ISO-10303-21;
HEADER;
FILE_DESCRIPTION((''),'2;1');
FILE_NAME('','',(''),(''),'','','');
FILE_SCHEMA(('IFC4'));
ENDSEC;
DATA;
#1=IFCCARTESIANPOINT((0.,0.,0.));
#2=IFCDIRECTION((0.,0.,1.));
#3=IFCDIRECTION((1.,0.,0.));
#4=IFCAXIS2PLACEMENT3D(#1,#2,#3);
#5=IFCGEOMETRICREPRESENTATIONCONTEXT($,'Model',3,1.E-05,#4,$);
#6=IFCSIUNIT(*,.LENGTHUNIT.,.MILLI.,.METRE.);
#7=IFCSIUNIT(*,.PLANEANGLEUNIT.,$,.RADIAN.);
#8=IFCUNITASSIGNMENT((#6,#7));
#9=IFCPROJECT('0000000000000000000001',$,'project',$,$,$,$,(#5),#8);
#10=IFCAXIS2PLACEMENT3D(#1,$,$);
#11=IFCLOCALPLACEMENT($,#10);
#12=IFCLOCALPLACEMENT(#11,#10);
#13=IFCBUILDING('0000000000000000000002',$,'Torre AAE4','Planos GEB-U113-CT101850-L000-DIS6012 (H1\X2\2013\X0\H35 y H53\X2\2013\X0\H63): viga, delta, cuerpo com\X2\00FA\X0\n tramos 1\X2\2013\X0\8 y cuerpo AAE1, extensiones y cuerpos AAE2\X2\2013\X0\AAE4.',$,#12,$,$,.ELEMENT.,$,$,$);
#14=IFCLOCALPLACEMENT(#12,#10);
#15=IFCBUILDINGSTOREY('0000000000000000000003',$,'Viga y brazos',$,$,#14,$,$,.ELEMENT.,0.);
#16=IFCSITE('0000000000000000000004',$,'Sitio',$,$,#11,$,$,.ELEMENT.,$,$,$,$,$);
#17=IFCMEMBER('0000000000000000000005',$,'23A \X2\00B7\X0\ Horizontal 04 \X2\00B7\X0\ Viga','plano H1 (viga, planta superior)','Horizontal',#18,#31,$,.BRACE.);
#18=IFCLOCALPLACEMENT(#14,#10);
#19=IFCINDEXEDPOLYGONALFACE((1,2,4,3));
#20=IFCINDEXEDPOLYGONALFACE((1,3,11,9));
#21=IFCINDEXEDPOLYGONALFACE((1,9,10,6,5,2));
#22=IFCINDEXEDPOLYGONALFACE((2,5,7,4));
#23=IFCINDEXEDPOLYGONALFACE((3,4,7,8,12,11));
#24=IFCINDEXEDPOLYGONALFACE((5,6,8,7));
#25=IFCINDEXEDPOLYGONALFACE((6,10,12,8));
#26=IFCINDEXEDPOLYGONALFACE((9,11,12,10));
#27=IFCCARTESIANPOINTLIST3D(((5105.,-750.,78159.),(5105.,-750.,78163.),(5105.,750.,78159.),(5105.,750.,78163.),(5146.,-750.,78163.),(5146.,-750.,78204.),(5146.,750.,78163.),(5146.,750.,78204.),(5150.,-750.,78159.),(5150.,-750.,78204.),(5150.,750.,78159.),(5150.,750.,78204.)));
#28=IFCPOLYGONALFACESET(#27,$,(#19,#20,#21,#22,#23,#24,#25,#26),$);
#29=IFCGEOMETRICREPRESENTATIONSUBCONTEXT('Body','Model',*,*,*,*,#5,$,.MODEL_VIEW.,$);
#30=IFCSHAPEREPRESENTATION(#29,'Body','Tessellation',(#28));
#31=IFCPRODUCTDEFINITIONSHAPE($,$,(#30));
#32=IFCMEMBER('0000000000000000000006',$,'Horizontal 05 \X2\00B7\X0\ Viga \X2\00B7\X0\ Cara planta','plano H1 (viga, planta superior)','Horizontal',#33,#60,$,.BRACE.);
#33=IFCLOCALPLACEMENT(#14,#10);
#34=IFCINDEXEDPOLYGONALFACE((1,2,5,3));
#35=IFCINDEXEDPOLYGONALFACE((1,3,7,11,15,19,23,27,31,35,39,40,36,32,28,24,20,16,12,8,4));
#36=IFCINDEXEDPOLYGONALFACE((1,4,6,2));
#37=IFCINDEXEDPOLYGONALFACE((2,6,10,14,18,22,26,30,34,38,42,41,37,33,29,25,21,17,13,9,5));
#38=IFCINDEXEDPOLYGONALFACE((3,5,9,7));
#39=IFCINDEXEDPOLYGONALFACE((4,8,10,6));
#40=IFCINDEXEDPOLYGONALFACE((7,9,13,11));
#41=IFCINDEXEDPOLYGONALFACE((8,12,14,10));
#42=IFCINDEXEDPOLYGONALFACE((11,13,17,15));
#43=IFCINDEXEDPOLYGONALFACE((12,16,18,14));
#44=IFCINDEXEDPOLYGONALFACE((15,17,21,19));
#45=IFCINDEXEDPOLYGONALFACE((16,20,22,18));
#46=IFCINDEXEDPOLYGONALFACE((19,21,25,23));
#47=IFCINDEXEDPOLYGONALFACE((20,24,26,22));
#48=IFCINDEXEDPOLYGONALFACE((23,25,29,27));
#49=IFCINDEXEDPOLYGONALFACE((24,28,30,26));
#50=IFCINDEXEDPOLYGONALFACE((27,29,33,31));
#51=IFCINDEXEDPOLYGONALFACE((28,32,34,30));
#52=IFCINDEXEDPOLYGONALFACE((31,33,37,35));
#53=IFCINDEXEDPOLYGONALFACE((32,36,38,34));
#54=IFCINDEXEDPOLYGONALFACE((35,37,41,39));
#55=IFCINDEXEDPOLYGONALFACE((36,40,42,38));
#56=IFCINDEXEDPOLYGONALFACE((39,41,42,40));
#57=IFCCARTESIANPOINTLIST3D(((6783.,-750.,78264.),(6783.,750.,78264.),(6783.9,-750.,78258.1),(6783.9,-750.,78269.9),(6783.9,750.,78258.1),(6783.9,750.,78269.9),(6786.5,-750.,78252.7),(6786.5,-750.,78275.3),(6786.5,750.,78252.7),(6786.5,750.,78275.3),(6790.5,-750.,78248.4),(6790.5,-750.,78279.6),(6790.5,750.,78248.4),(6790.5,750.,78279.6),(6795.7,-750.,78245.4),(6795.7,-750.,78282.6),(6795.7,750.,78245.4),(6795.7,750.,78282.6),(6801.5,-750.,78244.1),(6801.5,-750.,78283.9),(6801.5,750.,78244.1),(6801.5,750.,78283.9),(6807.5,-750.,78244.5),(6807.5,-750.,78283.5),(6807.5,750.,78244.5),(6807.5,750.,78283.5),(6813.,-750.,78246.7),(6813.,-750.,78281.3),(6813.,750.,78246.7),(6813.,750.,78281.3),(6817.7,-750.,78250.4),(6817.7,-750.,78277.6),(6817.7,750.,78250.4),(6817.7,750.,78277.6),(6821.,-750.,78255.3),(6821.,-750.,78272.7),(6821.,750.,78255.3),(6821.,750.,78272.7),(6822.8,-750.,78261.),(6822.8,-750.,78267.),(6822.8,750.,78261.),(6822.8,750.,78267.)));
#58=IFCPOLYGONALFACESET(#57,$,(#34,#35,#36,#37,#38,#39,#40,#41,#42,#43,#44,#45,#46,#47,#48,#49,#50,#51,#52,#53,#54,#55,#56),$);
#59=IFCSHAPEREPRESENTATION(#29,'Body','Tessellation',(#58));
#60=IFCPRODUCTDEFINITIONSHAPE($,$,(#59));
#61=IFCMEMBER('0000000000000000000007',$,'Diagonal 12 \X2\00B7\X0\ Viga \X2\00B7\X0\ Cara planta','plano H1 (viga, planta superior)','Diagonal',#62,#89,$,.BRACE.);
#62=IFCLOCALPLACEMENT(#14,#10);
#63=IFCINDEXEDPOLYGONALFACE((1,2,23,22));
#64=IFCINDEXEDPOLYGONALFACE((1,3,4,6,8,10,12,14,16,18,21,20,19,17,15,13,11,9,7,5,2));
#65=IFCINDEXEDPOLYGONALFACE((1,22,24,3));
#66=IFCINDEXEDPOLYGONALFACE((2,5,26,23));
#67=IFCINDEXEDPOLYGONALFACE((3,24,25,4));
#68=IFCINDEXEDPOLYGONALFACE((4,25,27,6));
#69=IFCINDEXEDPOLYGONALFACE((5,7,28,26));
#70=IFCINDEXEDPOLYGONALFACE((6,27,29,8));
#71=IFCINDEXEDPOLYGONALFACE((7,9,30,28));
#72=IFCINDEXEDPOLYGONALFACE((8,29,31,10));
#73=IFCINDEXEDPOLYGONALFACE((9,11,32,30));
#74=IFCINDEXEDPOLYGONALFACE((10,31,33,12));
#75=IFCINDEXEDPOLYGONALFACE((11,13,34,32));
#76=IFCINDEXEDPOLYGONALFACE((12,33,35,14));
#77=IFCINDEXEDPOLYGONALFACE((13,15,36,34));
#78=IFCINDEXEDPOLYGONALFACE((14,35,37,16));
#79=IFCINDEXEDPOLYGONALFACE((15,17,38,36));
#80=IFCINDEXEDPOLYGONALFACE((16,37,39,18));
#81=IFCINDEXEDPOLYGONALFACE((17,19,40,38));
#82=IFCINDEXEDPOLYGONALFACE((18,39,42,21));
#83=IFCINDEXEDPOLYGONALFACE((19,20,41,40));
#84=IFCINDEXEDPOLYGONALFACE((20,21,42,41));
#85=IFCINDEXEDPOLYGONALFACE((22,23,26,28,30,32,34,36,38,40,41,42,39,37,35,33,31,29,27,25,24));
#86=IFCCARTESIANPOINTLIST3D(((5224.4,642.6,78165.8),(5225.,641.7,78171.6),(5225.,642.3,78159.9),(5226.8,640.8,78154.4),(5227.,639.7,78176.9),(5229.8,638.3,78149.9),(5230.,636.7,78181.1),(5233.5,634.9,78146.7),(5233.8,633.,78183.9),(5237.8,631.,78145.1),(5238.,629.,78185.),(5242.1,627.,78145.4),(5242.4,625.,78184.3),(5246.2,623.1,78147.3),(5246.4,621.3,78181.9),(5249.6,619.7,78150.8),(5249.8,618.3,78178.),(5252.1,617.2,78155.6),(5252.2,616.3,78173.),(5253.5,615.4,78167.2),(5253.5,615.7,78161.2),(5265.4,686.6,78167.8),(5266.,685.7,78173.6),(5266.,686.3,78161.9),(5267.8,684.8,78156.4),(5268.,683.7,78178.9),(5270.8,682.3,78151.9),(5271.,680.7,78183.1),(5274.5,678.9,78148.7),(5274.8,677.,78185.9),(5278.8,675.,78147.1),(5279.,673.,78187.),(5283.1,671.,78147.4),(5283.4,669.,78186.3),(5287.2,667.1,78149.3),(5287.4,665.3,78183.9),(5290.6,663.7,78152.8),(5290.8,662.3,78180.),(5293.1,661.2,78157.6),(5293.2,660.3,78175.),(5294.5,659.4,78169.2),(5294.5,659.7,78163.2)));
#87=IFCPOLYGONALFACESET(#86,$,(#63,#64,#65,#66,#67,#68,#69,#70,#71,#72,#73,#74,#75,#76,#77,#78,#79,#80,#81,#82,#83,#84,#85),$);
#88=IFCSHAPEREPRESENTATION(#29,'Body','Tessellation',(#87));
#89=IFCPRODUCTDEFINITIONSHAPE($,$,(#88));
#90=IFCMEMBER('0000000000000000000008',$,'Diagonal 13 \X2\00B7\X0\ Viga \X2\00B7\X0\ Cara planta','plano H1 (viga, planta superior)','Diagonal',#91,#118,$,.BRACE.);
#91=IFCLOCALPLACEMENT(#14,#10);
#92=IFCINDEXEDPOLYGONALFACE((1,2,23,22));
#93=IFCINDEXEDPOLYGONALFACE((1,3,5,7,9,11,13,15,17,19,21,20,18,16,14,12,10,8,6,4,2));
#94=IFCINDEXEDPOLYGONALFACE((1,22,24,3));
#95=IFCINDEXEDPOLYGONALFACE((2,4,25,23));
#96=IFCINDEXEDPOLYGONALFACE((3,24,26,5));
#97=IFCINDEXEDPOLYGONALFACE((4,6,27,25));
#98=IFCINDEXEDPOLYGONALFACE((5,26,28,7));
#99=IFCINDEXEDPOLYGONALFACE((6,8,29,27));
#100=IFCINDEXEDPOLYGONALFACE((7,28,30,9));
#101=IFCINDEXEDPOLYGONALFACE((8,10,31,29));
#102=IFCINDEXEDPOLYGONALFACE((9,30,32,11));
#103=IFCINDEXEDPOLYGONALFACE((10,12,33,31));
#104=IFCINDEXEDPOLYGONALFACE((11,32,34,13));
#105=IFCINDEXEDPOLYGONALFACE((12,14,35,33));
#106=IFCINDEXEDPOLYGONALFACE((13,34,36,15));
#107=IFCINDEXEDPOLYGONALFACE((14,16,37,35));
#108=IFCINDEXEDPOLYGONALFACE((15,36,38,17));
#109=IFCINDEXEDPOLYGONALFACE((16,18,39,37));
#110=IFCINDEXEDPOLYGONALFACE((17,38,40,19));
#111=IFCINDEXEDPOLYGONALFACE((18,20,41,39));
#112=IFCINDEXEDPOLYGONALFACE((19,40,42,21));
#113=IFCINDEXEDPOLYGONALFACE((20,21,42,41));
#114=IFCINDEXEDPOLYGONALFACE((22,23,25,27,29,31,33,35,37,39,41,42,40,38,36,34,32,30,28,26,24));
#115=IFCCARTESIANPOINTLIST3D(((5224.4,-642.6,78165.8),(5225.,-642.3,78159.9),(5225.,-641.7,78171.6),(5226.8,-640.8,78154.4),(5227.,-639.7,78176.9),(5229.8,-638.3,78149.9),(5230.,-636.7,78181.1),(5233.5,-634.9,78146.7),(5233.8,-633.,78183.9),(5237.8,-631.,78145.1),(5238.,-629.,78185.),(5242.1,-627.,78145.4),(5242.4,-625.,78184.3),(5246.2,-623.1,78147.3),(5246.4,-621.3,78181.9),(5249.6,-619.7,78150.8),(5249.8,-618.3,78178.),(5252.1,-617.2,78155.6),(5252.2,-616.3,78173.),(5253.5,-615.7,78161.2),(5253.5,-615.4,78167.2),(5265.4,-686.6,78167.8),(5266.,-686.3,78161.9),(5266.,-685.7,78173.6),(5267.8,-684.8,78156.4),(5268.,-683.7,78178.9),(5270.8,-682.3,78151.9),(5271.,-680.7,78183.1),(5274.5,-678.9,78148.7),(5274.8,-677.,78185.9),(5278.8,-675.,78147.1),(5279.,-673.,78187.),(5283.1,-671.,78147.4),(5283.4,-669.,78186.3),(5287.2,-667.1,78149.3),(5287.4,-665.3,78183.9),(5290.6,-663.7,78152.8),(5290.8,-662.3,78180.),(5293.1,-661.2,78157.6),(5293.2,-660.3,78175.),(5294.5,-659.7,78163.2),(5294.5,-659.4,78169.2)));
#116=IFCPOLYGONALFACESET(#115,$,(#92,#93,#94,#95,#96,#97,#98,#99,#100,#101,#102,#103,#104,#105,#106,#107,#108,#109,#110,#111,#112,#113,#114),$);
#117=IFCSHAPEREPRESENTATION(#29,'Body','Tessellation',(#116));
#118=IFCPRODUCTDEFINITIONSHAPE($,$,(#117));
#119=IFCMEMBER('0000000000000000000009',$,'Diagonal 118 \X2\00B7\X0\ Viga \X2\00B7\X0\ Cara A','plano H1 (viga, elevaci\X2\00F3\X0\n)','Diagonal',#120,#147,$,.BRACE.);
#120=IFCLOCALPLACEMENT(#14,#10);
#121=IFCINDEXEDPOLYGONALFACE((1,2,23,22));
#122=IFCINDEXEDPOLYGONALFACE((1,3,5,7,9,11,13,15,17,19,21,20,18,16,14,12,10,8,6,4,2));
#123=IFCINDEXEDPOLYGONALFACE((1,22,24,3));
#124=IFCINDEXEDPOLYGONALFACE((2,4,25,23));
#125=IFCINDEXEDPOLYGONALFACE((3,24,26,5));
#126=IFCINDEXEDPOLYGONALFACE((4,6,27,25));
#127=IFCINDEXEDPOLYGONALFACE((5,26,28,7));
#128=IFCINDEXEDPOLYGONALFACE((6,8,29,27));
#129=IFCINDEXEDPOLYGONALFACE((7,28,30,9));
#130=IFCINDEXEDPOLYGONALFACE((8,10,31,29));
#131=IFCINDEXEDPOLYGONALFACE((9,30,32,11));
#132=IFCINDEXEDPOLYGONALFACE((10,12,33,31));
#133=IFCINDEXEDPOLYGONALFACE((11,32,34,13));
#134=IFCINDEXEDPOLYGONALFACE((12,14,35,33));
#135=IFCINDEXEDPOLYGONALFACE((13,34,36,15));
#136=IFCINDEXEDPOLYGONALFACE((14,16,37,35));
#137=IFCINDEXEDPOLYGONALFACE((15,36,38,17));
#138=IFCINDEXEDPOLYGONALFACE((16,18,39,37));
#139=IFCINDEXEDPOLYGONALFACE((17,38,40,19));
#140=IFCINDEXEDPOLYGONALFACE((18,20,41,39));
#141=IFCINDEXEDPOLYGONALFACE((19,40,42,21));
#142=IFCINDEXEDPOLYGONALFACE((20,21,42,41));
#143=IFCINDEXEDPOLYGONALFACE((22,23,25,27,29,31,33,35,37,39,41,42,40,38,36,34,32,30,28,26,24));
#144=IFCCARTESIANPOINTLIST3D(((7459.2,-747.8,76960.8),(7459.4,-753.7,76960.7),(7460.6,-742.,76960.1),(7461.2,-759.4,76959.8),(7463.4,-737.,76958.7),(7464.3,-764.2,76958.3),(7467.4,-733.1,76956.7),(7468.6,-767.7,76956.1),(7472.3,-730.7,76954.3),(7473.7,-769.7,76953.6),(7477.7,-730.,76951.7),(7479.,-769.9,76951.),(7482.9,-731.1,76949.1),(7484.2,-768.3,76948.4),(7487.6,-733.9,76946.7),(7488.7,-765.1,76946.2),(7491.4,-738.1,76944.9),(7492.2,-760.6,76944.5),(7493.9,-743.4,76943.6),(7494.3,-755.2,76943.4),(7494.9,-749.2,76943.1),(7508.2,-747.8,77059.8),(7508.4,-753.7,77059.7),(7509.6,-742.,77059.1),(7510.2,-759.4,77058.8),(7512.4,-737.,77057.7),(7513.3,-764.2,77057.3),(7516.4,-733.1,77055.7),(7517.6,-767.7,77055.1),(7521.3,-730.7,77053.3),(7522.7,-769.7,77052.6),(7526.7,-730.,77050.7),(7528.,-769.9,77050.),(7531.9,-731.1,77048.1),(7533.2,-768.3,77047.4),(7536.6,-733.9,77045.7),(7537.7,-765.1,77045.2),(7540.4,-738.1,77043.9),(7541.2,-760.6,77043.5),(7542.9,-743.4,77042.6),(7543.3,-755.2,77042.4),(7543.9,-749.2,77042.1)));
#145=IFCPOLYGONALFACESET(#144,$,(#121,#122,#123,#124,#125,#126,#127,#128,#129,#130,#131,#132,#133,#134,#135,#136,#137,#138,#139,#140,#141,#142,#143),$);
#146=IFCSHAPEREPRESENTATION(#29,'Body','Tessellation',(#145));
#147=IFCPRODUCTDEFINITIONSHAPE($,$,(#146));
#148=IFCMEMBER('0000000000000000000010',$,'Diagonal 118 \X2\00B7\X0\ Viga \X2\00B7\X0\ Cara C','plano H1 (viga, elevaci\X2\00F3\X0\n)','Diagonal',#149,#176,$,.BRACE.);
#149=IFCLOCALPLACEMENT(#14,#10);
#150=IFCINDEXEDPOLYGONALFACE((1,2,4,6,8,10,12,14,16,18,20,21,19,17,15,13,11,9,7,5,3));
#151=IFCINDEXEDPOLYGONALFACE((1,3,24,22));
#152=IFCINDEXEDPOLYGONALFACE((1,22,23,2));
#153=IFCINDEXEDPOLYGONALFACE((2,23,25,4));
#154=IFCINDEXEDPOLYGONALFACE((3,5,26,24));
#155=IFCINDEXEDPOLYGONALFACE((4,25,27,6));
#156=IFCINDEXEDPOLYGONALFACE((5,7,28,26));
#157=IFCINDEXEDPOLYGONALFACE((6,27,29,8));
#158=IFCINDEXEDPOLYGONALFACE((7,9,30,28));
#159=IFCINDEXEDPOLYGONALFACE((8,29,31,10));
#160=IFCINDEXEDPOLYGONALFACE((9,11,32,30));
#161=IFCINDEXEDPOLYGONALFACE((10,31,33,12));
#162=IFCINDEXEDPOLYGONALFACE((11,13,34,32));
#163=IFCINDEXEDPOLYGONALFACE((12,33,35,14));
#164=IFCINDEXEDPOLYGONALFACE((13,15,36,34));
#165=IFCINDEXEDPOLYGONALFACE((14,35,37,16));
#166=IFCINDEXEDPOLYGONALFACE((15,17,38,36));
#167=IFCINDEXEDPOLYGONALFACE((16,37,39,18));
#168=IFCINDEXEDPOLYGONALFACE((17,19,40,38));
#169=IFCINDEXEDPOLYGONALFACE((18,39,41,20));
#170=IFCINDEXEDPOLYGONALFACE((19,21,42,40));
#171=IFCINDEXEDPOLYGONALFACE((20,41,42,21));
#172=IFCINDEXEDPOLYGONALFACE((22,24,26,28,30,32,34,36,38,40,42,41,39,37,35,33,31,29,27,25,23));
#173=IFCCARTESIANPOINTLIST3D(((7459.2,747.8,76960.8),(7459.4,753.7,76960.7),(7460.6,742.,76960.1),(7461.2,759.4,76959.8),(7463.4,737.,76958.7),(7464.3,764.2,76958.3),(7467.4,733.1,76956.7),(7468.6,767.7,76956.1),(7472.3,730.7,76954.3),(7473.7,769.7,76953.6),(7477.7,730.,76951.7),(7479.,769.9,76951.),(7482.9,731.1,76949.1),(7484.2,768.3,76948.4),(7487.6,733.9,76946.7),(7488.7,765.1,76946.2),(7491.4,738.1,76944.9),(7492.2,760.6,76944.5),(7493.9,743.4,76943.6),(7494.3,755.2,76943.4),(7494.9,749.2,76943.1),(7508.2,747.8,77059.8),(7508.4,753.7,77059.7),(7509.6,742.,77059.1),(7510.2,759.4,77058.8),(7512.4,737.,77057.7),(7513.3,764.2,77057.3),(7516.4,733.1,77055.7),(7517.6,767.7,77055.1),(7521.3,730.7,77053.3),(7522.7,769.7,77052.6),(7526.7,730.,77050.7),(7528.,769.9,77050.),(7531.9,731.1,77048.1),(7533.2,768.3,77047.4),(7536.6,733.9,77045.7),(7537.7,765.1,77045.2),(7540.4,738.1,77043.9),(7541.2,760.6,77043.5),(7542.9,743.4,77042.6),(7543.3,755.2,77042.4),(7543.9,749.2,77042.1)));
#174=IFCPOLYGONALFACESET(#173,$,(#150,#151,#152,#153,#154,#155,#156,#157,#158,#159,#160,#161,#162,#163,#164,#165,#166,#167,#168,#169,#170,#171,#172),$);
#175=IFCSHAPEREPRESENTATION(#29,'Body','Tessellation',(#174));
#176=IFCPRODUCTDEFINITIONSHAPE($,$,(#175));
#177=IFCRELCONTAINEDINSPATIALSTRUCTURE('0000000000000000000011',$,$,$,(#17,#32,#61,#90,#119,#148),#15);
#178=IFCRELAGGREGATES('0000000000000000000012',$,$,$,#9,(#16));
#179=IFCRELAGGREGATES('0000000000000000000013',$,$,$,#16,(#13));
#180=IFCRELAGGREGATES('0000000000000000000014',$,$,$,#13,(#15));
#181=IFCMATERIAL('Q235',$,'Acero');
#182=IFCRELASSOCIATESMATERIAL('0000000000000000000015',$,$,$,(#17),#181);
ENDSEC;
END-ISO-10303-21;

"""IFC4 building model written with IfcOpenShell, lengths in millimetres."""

from ifc_helpers import new_model, si_unit, frame, frame_2d, origin, origin_with_axes, place, context, subcontext, project, spatial, circle, l_section, extrude, material, element, save


model = new_model("IFC4")

# Units and contexts
model_context = context("Model", 3, precision=1e-05, world=origin_with_axes())
body_context = subcontext(model_context, "Body", "Model", "MODEL_VIEW")
ifc_project = project(units=[si_unit("LENGTHUNIT", "METRE", prefix="MILLI"), si_unit("PLANEANGLEUNIT", "RADIAN")], contexts=[model_context])

# Site, building, storey
site_placement = place(None, origin())
site = spatial("IfcSite", under=ifc_project, at=site_placement, Name="Sitio", CompositionType="ELEMENT")
building_placement = place(site_placement, origin())
building = spatial("IfcBuilding", under=site, at=building_placement, Name="Torre AAE4", Description="Planos GEB-U113-CT101850-L000-DIS6012 (H1–H35 y H53–H63): viga, delta, cuerpo común tramos 1–8 y cuerpo AAE1, extensiones y cuerpos AAE2–AAE4.", CompositionType="ELEMENT")
storey_placement = place(building_placement, origin())
storey = spatial("IfcBuildingStorey", under=building, at=storey_placement, Name="Viga y brazos", CompositionType="ELEMENT", Elevation=0.0)

# Members
ifc_material = material(Name="Q235", Category="Acero")
member_1_placement = place(storey_placement, frame((5150.0, -750.0, 78159.0), z_axis=(0.0, 1.0, 0.0), x_axis=(-1.0, 0.0, 0.0)))
element("IfcMember", 1, at=member_1_placement, inside=storey, material=ifc_material, Name="23A · Horizontal 04 · Viga", Description="plano H1 (viga, planta superior)", ObjectType="Horizontal", PredefinedType="BRACE", context=body_context, shape_type="SweptSolid", body=[
    extrude(l_section(Depth=45.0, Width=45.0, Thickness=4.0, at=frame_2d((22.5, 22.5))), None, (0.0, 0.0, 1.0), 1500.0),
])
member_2_placement = place(storey_placement, frame((6803.0, -750.0, 78264.0), z_axis=(0.0, 1.0, 0.0), x_axis=(-1.0, 0.0, 0.0)))
element("IfcMember", 2, at=member_2_placement, inside=storey, Name="Horizontal 05 · Viga · Cara planta", Description="plano H1 (viga, planta superior)", ObjectType="Horizontal", PredefinedType="BRACE", context=body_context, shape_type="SweptSolid", body=[
    extrude(circle(Radius=20.0), None, (0.0, 0.0, 1.0), 1500.0),
])
for number, where, z_axis, x_axis, name in (
    (3, (5280.0, 673.0, 78167.0), (-0.681349, -0.731204, -0.033237), (-0.731931, 0.680227, 0.039605), "Diagonal 12 · Viga · Cara planta"),
    (4, (5280.0, -673.0, 78167.0), (-0.681349, 0.731204, -0.033237), (-0.731931, -0.680227, 0.039605), "Diagonal 13 · Viga · Cara planta"),
):
    element("IfcMember", number, at=place(storey_placement, frame(where, z_axis=z_axis, x_axis=x_axis)), inside=storey, Name=name, Description="plano H1 (viga, planta superior)", ObjectType="Diagonal", PredefinedType="BRACE", context=body_context, shape_type="SweptSolid", body=[
        extrude(circle(Radius=20.0), None, (0.0, 0.0, 1.0), 60.2),
    ])
for number, where, z_axis, x_axis, name in (
    (5, (7477.0, -750.0, 76952.0), (0.443589, 0.0, 0.89623), (-0.890705, 0.110868, 0.440854), "Diagonal 118 · Viga · Cara A"),
    (6, (7477.0, 750.0, 76952.0), (0.443589, 0.0, 0.89623), (-0.890705, -0.110868, 0.440854), "Diagonal 118 · Viga · Cara C"),
):
    element("IfcMember", number, at=place(storey_placement, frame(where, z_axis=z_axis, x_axis=x_axis)), inside=storey, Name=name, Description="plano H1 (viga, elevación)", ObjectType="Diagonal", PredefinedType="BRACE", context=body_context, shape_type="SweptSolid", body=[
        extrude(circle(Radius=20.0), None, (0.0, 0.0, 1.0), 110.5),
    ])

save(model, "model.ifc")
